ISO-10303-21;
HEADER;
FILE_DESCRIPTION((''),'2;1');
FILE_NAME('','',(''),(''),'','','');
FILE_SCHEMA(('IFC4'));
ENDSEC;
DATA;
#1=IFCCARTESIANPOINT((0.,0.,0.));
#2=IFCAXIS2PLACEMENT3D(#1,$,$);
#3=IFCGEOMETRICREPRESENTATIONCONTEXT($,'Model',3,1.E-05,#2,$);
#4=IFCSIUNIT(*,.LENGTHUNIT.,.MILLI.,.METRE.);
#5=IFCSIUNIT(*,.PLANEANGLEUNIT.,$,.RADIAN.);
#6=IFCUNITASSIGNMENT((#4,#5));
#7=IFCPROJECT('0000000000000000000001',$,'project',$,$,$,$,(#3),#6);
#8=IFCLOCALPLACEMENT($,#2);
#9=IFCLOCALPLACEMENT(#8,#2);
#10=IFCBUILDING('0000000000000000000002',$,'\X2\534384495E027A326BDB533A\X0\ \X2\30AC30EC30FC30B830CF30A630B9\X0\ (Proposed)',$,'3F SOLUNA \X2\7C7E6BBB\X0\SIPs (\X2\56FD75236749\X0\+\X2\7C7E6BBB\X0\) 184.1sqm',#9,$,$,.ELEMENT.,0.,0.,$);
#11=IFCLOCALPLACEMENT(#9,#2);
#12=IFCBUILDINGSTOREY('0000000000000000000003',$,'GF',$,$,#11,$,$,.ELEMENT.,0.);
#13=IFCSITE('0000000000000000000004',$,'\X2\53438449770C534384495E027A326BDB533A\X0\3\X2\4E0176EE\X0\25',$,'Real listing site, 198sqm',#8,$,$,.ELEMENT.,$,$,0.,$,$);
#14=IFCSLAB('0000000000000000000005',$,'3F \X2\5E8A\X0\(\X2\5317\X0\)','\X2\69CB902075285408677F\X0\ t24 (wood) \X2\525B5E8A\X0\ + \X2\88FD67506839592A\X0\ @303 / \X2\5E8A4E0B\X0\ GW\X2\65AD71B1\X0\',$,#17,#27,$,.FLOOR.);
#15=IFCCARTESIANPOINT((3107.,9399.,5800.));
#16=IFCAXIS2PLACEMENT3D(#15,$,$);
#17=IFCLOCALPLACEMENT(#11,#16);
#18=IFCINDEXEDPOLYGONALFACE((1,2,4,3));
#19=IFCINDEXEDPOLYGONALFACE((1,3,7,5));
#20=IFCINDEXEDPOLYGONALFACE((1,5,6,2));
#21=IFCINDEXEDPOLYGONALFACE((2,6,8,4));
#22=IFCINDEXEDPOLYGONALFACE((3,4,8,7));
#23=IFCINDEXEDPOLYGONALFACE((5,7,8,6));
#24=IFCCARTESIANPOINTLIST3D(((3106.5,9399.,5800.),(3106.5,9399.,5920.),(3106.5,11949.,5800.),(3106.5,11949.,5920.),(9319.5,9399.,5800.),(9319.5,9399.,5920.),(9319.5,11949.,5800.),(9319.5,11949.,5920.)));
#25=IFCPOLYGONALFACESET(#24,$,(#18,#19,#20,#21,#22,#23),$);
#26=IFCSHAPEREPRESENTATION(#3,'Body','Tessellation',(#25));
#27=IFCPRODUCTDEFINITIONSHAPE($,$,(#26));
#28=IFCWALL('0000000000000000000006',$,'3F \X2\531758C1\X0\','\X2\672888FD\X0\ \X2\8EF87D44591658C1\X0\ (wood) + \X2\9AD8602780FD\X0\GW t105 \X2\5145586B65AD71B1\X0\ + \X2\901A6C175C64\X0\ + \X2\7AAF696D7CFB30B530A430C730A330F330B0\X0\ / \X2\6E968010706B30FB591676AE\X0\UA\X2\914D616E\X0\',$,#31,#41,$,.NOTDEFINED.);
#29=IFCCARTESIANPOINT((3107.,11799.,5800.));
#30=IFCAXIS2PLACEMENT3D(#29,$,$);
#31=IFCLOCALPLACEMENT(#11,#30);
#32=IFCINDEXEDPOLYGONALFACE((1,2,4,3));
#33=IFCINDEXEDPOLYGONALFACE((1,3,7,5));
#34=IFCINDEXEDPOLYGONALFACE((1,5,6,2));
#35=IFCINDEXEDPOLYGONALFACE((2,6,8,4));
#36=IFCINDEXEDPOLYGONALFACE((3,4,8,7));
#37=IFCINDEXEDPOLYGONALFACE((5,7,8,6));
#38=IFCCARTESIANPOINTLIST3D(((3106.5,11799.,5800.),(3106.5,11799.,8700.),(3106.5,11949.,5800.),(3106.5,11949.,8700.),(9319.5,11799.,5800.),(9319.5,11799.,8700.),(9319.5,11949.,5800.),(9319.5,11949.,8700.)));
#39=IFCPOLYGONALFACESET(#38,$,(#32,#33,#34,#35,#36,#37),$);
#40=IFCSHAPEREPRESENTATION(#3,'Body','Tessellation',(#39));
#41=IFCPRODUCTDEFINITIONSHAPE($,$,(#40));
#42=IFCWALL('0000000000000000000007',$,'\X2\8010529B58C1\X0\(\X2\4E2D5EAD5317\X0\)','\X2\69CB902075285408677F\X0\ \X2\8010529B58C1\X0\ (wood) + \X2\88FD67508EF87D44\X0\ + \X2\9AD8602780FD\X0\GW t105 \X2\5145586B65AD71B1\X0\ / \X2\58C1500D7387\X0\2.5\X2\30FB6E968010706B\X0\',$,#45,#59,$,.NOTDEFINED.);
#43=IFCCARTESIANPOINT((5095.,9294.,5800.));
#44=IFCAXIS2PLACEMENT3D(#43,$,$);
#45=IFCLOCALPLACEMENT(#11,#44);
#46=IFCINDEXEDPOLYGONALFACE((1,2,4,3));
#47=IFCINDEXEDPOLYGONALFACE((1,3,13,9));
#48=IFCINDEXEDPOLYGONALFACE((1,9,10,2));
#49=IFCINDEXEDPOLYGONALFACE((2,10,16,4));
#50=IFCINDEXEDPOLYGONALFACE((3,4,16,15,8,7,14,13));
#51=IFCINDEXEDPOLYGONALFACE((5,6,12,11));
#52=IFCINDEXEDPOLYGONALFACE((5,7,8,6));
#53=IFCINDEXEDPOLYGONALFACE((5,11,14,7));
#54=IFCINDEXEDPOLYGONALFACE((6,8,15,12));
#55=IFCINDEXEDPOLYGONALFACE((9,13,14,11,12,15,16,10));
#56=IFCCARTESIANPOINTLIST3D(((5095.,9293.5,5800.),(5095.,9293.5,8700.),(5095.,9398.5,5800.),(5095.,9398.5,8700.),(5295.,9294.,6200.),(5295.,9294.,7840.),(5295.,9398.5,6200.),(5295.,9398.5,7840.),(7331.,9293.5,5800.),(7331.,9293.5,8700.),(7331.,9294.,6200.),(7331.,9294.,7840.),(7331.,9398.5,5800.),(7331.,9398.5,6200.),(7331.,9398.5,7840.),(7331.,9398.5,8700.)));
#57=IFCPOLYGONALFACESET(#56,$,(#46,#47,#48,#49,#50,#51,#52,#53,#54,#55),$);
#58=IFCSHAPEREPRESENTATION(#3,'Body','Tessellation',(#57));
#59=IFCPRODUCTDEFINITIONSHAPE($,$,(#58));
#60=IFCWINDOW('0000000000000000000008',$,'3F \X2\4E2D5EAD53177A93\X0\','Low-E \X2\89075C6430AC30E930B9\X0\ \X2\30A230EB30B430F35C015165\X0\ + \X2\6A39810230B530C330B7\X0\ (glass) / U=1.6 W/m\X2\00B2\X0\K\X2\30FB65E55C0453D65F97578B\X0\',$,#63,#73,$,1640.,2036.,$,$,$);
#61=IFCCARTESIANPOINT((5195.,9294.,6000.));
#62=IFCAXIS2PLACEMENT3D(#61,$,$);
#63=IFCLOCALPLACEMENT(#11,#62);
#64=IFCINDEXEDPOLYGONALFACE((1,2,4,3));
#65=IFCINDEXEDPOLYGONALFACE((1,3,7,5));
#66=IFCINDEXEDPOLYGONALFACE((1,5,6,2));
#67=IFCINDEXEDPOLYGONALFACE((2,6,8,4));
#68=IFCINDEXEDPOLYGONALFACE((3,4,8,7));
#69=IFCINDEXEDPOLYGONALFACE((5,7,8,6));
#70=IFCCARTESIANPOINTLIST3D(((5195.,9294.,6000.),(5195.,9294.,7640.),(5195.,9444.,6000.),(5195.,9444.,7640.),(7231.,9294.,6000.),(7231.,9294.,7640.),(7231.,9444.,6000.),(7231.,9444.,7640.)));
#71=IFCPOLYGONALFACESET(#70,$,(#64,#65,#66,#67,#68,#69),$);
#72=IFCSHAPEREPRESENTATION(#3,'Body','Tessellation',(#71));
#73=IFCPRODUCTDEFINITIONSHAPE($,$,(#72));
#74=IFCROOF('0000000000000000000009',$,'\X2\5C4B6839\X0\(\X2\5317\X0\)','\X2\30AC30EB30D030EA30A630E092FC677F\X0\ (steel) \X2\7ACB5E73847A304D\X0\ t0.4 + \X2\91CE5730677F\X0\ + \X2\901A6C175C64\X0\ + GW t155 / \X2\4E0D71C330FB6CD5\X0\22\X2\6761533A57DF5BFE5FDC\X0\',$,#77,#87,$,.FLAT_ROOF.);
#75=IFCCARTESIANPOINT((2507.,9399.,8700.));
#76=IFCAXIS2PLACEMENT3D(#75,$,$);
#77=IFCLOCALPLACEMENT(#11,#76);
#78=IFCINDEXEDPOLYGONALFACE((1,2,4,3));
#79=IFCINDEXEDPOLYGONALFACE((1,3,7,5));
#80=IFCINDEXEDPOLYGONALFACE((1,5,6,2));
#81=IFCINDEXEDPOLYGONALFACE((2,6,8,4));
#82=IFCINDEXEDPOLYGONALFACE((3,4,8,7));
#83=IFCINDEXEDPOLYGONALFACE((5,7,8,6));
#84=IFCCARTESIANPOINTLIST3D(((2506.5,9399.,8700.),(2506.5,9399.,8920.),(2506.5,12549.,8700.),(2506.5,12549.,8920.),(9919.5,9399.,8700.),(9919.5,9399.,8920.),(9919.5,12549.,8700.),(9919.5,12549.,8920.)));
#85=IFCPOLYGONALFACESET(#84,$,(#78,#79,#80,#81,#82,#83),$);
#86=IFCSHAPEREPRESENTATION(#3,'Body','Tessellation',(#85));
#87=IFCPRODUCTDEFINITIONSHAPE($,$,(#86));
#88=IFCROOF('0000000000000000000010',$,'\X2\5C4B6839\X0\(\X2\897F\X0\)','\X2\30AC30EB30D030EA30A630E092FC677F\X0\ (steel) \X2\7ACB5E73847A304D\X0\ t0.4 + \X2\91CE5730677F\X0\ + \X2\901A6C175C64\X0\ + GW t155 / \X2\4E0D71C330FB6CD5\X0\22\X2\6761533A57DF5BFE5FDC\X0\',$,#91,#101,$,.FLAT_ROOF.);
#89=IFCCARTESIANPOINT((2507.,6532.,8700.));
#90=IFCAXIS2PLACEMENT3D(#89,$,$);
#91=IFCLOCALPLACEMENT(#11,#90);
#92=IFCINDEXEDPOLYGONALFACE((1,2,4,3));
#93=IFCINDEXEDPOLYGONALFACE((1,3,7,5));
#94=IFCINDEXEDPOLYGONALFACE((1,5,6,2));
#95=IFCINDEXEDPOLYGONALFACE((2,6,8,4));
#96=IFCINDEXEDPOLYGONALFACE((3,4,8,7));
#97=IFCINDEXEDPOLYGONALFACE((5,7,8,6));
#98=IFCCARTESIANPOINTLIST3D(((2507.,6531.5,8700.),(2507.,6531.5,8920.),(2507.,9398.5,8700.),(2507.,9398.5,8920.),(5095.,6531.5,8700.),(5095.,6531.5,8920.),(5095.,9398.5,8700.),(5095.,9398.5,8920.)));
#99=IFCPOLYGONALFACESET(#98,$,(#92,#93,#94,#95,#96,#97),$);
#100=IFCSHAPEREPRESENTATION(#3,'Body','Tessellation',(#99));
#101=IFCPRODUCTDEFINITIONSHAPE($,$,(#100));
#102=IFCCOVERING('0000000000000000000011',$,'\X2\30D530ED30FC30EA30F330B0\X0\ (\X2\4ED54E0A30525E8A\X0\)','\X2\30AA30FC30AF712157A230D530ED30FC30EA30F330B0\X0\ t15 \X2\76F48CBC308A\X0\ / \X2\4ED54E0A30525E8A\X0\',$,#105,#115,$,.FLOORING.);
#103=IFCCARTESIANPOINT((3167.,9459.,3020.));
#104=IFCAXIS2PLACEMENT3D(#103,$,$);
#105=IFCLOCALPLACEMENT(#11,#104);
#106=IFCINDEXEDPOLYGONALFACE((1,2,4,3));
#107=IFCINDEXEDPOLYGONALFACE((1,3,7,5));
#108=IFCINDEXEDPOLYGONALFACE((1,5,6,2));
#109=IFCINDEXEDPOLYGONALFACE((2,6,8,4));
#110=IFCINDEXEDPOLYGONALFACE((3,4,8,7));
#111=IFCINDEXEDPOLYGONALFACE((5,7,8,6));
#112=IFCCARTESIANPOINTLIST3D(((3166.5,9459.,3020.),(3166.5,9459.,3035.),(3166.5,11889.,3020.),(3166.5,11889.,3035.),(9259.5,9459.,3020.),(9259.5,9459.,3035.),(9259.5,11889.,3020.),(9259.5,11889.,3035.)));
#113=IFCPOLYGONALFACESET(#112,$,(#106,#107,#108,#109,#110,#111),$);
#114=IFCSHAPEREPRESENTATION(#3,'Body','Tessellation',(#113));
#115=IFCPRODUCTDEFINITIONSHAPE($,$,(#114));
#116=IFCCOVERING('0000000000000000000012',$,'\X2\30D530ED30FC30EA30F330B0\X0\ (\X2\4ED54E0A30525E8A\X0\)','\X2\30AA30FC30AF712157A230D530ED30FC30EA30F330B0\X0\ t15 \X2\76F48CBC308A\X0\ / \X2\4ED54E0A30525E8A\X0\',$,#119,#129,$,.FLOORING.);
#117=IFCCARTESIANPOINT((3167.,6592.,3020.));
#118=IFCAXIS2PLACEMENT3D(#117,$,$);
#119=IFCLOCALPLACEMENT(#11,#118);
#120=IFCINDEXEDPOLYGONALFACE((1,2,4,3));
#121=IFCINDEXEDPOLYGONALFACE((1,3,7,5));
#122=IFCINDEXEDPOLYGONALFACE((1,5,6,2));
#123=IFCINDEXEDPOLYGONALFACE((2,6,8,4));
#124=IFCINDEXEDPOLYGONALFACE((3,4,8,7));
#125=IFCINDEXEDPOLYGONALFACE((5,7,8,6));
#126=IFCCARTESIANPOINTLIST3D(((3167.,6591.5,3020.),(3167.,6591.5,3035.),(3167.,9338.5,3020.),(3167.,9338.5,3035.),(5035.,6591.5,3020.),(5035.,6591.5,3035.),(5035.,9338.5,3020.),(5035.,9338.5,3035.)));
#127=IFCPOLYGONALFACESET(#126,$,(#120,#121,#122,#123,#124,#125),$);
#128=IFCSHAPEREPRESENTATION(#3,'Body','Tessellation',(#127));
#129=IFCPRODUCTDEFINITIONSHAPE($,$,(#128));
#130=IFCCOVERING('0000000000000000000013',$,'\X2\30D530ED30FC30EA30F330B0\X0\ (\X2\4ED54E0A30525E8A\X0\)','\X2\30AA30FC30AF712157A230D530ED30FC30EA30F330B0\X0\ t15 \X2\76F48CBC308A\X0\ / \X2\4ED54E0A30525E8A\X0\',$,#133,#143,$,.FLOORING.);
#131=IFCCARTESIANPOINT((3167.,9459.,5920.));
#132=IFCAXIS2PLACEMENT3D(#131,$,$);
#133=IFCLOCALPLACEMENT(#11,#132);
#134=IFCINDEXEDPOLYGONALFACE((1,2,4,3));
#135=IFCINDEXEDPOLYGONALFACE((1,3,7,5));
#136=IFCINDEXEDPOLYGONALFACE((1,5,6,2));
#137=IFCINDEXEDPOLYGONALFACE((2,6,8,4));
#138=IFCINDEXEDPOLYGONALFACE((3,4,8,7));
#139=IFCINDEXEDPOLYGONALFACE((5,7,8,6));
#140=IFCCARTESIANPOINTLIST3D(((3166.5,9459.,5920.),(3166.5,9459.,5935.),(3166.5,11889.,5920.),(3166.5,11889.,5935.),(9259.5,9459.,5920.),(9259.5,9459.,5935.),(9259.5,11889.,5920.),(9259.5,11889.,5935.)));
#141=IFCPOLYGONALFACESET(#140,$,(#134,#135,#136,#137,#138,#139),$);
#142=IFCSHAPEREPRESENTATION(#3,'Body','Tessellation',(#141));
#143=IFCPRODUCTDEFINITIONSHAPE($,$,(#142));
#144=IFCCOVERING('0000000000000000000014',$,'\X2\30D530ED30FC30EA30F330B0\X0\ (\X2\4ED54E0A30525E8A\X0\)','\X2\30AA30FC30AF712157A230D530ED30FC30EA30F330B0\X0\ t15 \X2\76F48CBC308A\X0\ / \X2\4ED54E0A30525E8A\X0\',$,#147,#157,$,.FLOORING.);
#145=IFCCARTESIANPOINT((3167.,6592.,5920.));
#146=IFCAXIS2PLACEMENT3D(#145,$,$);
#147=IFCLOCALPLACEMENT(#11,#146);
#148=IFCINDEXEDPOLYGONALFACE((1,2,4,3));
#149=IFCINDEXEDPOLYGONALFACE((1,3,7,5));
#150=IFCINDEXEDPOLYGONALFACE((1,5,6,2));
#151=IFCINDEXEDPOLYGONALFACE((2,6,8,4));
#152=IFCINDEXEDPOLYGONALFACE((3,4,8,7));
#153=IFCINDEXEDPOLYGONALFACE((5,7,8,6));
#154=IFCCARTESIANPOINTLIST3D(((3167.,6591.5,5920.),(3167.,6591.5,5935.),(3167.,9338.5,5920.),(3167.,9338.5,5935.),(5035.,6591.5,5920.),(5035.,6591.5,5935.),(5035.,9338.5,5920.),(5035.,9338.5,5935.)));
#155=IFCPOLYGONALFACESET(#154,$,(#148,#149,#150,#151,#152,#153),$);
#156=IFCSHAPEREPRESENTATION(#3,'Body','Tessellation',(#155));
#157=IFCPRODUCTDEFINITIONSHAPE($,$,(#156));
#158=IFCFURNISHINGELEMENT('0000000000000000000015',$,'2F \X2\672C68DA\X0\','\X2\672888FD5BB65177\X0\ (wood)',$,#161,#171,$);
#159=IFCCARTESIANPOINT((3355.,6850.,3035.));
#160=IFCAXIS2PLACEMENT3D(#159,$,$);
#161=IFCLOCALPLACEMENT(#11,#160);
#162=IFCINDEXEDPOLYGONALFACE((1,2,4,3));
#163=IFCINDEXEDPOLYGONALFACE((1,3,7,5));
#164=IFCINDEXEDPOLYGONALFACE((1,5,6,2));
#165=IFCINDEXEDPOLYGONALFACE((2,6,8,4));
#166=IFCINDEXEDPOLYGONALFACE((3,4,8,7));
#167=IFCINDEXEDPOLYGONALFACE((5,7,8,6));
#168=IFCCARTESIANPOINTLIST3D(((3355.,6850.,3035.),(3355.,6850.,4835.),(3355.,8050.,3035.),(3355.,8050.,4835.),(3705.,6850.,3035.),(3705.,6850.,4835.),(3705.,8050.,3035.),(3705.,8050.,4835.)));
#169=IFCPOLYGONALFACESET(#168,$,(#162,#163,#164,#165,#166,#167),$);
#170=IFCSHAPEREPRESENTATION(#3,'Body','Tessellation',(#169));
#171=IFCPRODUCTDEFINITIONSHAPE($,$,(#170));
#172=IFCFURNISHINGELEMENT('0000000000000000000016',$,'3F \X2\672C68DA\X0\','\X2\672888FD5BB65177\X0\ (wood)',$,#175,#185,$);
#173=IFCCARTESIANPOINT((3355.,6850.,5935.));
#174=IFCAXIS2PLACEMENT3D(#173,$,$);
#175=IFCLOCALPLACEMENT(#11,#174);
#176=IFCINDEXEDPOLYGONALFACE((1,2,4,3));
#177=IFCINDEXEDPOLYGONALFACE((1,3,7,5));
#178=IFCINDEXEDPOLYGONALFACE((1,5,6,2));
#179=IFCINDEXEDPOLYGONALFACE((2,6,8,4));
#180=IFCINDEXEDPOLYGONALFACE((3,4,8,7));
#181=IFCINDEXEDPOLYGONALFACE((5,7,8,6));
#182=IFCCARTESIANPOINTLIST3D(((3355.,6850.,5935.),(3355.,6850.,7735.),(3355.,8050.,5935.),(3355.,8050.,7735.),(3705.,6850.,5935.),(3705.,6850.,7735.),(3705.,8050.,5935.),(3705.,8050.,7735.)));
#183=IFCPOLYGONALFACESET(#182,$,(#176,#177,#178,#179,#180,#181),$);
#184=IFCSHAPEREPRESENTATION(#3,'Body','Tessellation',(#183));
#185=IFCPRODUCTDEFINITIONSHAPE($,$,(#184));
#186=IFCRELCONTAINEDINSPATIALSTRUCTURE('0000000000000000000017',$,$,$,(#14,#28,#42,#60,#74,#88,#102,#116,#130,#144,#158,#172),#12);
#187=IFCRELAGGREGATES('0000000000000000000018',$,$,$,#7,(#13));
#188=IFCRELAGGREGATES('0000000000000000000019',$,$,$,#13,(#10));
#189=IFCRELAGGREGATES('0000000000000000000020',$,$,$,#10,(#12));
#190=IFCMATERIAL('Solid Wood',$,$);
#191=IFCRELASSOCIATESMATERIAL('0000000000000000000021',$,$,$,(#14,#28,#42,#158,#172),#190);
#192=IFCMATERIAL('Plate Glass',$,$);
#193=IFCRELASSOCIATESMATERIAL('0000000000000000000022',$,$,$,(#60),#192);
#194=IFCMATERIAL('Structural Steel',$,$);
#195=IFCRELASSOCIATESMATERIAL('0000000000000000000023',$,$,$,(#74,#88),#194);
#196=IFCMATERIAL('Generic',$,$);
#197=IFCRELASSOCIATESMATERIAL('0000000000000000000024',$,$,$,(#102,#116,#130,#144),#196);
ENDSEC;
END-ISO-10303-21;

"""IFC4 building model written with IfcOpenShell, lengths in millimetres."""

from ifc_helpers import new_model, si_unit, frame, frame_2d, origin, place, context, project, spatial, rectangle, extrude, material, element, fill, save


model = new_model("IFC4")

# Units and contexts
model_context = context("Model", 3, precision=1e-05, world=origin())
ifc_project = project(units=[si_unit("LENGTHUNIT", "METRE", prefix="MILLI"), si_unit("PLANEANGLEUNIT", "RADIAN")], contexts=[model_context])

# Site, building, storey
site_placement = place(None, origin())
site = spatial("IfcSite", under=ifc_project, at=site_placement, Name="千葉県千葉市稲毛区3丁目25", ObjectType="Real listing site, 198sqm", CompositionType="ELEMENT", RefElevation=0.0)
building_placement = place(site_placement, origin())
building = spatial("IfcBuilding", under=site, at=building_placement, Name="千葉市稲毛区 ガレージハウス (Proposed)", ObjectType="3F SOLUNA 籾殻SIPs (国産杉+籾殻) 184.1sqm", CompositionType="ELEMENT", ElevationOfRefHeight=0.0, ElevationOfTerrain=0.0)
storey_placement = place(building_placement, origin())
storey = spatial("IfcBuildingStorey", under=building, at=storey_placement, Name="GF", CompositionType="ELEMENT", Elevation=0.0)

# Slab
ifc_material_1 = material(Name="Solid Wood")
slab_placement = place(storey_placement, frame((3107.0, 9399.0, 5800.0)))
element("IfcSlab", 1, at=slab_placement, inside=storey, material=ifc_material_1, Name="3F 床(北)", Description="構造用合板 t24 (wood) 剛床 + 製材根太 @303 / 床下 GW断熱", PredefinedType="FLOOR", context=model_context, shape_type="SweptSolid", body=[
    extrude(rectangle(XDim=6213.0, YDim=2550.0, at=frame_2d((3106.0, 1275.0))), frame((3107.0, 9399.0, 5800.0)), (0.0, 0.0, 1.0), 120.0),
])

# Wall
wall_1_placement = place(storey_placement, frame((3107.0, 11799.0, 5800.0)))
element("IfcWall", 2, at=wall_1_placement, inside=storey, material=ifc_material_1, Name="3F 北壁", Description="木製 軸組外壁 (wood) + 高性能GW t105 充填断熱 + 通気層 + 窯業系サイディング / 準耐火・外皮UA配慮", PredefinedType="NOTDEFINED", context=model_context, shape_type="SweptSolid", body=[
    extrude(rectangle(XDim=6213.0, YDim=150.0, at=frame_2d((3106.0, 75.0))), frame((3107.0, 11799.0, 5800.0)), (0.0, 0.0, 1.0), 2900.0),
])

# Wall, opening, window
wall_2_placement = place(storey_placement, frame((5095.0, 9294.0, 5800.0)))
wall_2 = element("IfcWall", 3, at=wall_2_placement, inside=storey, material=ifc_material_1, Name="耐力壁(中庭北)", Description="構造用合板 耐力壁 (wood) + 製材軸組 + 高性能GW t105 充填断熱 / 壁倍率2.5・準耐火", PredefinedType="NOTDEFINED", context=model_context, shape_type="SweptSolid", body=[
    extrude(rectangle(XDim=2236.0, YDim=105.0, at=frame_2d((1118.0, 52.0))), frame((5095.0, 9294.0, 5800.0)), (0.0, 0.0, 1.0), 2900.0),
])
opening_placement = place(storey_placement, frame((5195.0, 9294.0, 6000.0)))
opening = element("IfcOpeningElement", 4, at=opening_placement, cuts=wall_2, PredefinedType="NOTDEFINED", context=model_context, shape_type="SweptSolid", body=[
    extrude(rectangle(XDim=2036.0, YDim=150.0, at=frame_2d((1018.0, 75.0))), frame((5195.0, 9294.0, 6000.0)), (0.0, 0.0, 1.0), 1640.0),
])
ifc_material_2 = material(Name="Plate Glass")
window_1_placement = place(storey_placement, frame((5195.0, 9294.0, 6000.0)))
window_1 = element("IfcWindow", 5, at=window_1_placement, inside=storey, material=ifc_material_2, Name="3F 中庭北窓", Description="Low-E 複層ガラス アルゴン封入 + 樹脂サッシ (glass) / U=1.6 W/m²K・日射取得型", OverallHeight=1640.0, OverallWidth=2036.0, context=model_context, shape_type="SweptSolid", body=[
    extrude(rectangle(XDim=2036.0, YDim=150.0, at=frame_2d((1018.0, 75.0))), frame((5195.0, 9294.0, 6000.0)), (0.0, 0.0, 1.0), 1640.0),
])
fill(opening, window_1)

# Shared definitions
ifc_material_3 = material(Name="Generic")

# Roofs
ifc_material_4 = material(Name="Structural Steel")
roof_1_placement = place(storey_placement, frame((2507.0, 9399.0, 8700.0)))
element("IfcRoof", 6, at=roof_1_placement, inside=storey, material=ifc_material_4, Name="屋根(北)", Description="ガルバリウム鋼板 (steel) 立平葺き t0.4 + 野地板 + 通気層 + GW t155 / 不燃・法22条区域対応", PredefinedType="FLAT_ROOF", context=model_context, shape_type="SweptSolid", body=[
    extrude(rectangle(XDim=7413.0, YDim=3150.0, at=frame_2d((3706.0, 1575.0))), frame((2507.0, 9399.0, 8700.0)), (0.0, 0.0, 1.0), 220.0),
])
roof_2_placement = place(storey_placement, frame((2507.0, 6532.0, 8700.0)))
element("IfcRoof", 7, at=roof_2_placement, inside=storey, material=ifc_material_4, Name="屋根(西)", Description="ガルバリウム鋼板 (steel) 立平葺き t0.4 + 野地板 + 通気層 + GW t155 / 不燃・法22条区域対応", PredefinedType="FLAT_ROOF", context=model_context, shape_type="SweptSolid", body=[
    extrude(rectangle(XDim=2588.0, YDim=2867.0, at=frame_2d((1294.0, 1433.0))), frame((2507.0, 6532.0, 8700.0)), (0.0, 0.0, 1.0), 220.0),
])

# Coverings
covering_1_placement = place(storey_placement, frame((3167.0, 9459.0, 3020.0)))
element("IfcCovering", 8, at=covering_1_placement, inside=storey, material=ifc_material_3, Name="フローリング (仕上げ床)", Description="オーク無垢フローリング t15 直貼り / 仕上げ床", PredefinedType="FLOORING", context=model_context, shape_type="SweptSolid", body=[
    extrude(rectangle(XDim=6093.0, YDim=2430.0, at=frame_2d((3046.0, 1215.0))), frame((3167.0, 9459.0, 3020.0)), (0.0, 0.0, 1.0), 15.0),
])
covering_2_placement = place(storey_placement, frame((3167.0, 6592.0, 3020.0)))
element("IfcCovering", 9, at=covering_2_placement, inside=storey, material=ifc_material_3, Name="フローリング (仕上げ床)", Description="オーク無垢フローリング t15 直貼り / 仕上げ床", PredefinedType="FLOORING", context=model_context, shape_type="SweptSolid", body=[
    extrude(rectangle(XDim=1868.0, YDim=2747.0, at=frame_2d((934.0, 1373.0))), frame((3167.0, 6592.0, 3020.0)), (0.0, 0.0, 1.0), 15.0),
])
covering_3_placement = place(storey_placement, frame((3167.0, 9459.0, 5920.0)))
element("IfcCovering", 10, at=covering_3_placement, inside=storey, material=ifc_material_3, Name="フローリング (仕上げ床)", Description="オーク無垢フローリング t15 直貼り / 仕上げ床", PredefinedType="FLOORING", context=model_context, shape_type="SweptSolid", body=[
    extrude(rectangle(XDim=6093.0, YDim=2430.0, at=frame_2d((3046.0, 1215.0))), frame((3167.0, 9459.0, 5920.0)), (0.0, 0.0, 1.0), 15.0),
])
covering_4_placement = place(storey_placement, frame((3167.0, 6592.0, 5920.0)))
element("IfcCovering", 11, at=covering_4_placement, inside=storey, material=ifc_material_3, Name="フローリング (仕上げ床)", Description="オーク無垢フローリング t15 直貼り / 仕上げ床", PredefinedType="FLOORING", context=model_context, shape_type="SweptSolid", body=[
    extrude(rectangle(XDim=1868.0, YDim=2747.0, at=frame_2d((934.0, 1373.0))), frame((3167.0, 6592.0, 5920.0)), (0.0, 0.0, 1.0), 15.0),
])

# Furnishing elements
furnishing_1_placement = place(storey_placement, frame((3355.0, 6850.0, 3035.0)))
element("IfcFurnishingElement", 12, at=furnishing_1_placement, inside=storey, material=ifc_material_1, Name="2F 本棚", Description="木製家具 (wood)", context=model_context, shape_type="SweptSolid", body=[
    extrude(rectangle(XDim=350.0, YDim=1200.0, at=frame_2d((175.0, 600.0))), frame((3355.0, 6850.0, 3035.0)), (0.0, 0.0, 1.0), 1800.0),
])
furnishing_2_placement = place(storey_placement, frame((3355.0, 6850.0, 5935.0)))
element("IfcFurnishingElement", 13, at=furnishing_2_placement, inside=storey, material=ifc_material_1, Name="3F 本棚", Description="木製家具 (wood)", context=model_context, shape_type="SweptSolid", body=[
    extrude(rectangle(XDim=350.0, YDim=1200.0, at=frame_2d((175.0, 600.0))), frame((3355.0, 6850.0, 5935.0)), (0.0, 0.0, 1.0), 1800.0),
])

save(model, "model.ifc")
